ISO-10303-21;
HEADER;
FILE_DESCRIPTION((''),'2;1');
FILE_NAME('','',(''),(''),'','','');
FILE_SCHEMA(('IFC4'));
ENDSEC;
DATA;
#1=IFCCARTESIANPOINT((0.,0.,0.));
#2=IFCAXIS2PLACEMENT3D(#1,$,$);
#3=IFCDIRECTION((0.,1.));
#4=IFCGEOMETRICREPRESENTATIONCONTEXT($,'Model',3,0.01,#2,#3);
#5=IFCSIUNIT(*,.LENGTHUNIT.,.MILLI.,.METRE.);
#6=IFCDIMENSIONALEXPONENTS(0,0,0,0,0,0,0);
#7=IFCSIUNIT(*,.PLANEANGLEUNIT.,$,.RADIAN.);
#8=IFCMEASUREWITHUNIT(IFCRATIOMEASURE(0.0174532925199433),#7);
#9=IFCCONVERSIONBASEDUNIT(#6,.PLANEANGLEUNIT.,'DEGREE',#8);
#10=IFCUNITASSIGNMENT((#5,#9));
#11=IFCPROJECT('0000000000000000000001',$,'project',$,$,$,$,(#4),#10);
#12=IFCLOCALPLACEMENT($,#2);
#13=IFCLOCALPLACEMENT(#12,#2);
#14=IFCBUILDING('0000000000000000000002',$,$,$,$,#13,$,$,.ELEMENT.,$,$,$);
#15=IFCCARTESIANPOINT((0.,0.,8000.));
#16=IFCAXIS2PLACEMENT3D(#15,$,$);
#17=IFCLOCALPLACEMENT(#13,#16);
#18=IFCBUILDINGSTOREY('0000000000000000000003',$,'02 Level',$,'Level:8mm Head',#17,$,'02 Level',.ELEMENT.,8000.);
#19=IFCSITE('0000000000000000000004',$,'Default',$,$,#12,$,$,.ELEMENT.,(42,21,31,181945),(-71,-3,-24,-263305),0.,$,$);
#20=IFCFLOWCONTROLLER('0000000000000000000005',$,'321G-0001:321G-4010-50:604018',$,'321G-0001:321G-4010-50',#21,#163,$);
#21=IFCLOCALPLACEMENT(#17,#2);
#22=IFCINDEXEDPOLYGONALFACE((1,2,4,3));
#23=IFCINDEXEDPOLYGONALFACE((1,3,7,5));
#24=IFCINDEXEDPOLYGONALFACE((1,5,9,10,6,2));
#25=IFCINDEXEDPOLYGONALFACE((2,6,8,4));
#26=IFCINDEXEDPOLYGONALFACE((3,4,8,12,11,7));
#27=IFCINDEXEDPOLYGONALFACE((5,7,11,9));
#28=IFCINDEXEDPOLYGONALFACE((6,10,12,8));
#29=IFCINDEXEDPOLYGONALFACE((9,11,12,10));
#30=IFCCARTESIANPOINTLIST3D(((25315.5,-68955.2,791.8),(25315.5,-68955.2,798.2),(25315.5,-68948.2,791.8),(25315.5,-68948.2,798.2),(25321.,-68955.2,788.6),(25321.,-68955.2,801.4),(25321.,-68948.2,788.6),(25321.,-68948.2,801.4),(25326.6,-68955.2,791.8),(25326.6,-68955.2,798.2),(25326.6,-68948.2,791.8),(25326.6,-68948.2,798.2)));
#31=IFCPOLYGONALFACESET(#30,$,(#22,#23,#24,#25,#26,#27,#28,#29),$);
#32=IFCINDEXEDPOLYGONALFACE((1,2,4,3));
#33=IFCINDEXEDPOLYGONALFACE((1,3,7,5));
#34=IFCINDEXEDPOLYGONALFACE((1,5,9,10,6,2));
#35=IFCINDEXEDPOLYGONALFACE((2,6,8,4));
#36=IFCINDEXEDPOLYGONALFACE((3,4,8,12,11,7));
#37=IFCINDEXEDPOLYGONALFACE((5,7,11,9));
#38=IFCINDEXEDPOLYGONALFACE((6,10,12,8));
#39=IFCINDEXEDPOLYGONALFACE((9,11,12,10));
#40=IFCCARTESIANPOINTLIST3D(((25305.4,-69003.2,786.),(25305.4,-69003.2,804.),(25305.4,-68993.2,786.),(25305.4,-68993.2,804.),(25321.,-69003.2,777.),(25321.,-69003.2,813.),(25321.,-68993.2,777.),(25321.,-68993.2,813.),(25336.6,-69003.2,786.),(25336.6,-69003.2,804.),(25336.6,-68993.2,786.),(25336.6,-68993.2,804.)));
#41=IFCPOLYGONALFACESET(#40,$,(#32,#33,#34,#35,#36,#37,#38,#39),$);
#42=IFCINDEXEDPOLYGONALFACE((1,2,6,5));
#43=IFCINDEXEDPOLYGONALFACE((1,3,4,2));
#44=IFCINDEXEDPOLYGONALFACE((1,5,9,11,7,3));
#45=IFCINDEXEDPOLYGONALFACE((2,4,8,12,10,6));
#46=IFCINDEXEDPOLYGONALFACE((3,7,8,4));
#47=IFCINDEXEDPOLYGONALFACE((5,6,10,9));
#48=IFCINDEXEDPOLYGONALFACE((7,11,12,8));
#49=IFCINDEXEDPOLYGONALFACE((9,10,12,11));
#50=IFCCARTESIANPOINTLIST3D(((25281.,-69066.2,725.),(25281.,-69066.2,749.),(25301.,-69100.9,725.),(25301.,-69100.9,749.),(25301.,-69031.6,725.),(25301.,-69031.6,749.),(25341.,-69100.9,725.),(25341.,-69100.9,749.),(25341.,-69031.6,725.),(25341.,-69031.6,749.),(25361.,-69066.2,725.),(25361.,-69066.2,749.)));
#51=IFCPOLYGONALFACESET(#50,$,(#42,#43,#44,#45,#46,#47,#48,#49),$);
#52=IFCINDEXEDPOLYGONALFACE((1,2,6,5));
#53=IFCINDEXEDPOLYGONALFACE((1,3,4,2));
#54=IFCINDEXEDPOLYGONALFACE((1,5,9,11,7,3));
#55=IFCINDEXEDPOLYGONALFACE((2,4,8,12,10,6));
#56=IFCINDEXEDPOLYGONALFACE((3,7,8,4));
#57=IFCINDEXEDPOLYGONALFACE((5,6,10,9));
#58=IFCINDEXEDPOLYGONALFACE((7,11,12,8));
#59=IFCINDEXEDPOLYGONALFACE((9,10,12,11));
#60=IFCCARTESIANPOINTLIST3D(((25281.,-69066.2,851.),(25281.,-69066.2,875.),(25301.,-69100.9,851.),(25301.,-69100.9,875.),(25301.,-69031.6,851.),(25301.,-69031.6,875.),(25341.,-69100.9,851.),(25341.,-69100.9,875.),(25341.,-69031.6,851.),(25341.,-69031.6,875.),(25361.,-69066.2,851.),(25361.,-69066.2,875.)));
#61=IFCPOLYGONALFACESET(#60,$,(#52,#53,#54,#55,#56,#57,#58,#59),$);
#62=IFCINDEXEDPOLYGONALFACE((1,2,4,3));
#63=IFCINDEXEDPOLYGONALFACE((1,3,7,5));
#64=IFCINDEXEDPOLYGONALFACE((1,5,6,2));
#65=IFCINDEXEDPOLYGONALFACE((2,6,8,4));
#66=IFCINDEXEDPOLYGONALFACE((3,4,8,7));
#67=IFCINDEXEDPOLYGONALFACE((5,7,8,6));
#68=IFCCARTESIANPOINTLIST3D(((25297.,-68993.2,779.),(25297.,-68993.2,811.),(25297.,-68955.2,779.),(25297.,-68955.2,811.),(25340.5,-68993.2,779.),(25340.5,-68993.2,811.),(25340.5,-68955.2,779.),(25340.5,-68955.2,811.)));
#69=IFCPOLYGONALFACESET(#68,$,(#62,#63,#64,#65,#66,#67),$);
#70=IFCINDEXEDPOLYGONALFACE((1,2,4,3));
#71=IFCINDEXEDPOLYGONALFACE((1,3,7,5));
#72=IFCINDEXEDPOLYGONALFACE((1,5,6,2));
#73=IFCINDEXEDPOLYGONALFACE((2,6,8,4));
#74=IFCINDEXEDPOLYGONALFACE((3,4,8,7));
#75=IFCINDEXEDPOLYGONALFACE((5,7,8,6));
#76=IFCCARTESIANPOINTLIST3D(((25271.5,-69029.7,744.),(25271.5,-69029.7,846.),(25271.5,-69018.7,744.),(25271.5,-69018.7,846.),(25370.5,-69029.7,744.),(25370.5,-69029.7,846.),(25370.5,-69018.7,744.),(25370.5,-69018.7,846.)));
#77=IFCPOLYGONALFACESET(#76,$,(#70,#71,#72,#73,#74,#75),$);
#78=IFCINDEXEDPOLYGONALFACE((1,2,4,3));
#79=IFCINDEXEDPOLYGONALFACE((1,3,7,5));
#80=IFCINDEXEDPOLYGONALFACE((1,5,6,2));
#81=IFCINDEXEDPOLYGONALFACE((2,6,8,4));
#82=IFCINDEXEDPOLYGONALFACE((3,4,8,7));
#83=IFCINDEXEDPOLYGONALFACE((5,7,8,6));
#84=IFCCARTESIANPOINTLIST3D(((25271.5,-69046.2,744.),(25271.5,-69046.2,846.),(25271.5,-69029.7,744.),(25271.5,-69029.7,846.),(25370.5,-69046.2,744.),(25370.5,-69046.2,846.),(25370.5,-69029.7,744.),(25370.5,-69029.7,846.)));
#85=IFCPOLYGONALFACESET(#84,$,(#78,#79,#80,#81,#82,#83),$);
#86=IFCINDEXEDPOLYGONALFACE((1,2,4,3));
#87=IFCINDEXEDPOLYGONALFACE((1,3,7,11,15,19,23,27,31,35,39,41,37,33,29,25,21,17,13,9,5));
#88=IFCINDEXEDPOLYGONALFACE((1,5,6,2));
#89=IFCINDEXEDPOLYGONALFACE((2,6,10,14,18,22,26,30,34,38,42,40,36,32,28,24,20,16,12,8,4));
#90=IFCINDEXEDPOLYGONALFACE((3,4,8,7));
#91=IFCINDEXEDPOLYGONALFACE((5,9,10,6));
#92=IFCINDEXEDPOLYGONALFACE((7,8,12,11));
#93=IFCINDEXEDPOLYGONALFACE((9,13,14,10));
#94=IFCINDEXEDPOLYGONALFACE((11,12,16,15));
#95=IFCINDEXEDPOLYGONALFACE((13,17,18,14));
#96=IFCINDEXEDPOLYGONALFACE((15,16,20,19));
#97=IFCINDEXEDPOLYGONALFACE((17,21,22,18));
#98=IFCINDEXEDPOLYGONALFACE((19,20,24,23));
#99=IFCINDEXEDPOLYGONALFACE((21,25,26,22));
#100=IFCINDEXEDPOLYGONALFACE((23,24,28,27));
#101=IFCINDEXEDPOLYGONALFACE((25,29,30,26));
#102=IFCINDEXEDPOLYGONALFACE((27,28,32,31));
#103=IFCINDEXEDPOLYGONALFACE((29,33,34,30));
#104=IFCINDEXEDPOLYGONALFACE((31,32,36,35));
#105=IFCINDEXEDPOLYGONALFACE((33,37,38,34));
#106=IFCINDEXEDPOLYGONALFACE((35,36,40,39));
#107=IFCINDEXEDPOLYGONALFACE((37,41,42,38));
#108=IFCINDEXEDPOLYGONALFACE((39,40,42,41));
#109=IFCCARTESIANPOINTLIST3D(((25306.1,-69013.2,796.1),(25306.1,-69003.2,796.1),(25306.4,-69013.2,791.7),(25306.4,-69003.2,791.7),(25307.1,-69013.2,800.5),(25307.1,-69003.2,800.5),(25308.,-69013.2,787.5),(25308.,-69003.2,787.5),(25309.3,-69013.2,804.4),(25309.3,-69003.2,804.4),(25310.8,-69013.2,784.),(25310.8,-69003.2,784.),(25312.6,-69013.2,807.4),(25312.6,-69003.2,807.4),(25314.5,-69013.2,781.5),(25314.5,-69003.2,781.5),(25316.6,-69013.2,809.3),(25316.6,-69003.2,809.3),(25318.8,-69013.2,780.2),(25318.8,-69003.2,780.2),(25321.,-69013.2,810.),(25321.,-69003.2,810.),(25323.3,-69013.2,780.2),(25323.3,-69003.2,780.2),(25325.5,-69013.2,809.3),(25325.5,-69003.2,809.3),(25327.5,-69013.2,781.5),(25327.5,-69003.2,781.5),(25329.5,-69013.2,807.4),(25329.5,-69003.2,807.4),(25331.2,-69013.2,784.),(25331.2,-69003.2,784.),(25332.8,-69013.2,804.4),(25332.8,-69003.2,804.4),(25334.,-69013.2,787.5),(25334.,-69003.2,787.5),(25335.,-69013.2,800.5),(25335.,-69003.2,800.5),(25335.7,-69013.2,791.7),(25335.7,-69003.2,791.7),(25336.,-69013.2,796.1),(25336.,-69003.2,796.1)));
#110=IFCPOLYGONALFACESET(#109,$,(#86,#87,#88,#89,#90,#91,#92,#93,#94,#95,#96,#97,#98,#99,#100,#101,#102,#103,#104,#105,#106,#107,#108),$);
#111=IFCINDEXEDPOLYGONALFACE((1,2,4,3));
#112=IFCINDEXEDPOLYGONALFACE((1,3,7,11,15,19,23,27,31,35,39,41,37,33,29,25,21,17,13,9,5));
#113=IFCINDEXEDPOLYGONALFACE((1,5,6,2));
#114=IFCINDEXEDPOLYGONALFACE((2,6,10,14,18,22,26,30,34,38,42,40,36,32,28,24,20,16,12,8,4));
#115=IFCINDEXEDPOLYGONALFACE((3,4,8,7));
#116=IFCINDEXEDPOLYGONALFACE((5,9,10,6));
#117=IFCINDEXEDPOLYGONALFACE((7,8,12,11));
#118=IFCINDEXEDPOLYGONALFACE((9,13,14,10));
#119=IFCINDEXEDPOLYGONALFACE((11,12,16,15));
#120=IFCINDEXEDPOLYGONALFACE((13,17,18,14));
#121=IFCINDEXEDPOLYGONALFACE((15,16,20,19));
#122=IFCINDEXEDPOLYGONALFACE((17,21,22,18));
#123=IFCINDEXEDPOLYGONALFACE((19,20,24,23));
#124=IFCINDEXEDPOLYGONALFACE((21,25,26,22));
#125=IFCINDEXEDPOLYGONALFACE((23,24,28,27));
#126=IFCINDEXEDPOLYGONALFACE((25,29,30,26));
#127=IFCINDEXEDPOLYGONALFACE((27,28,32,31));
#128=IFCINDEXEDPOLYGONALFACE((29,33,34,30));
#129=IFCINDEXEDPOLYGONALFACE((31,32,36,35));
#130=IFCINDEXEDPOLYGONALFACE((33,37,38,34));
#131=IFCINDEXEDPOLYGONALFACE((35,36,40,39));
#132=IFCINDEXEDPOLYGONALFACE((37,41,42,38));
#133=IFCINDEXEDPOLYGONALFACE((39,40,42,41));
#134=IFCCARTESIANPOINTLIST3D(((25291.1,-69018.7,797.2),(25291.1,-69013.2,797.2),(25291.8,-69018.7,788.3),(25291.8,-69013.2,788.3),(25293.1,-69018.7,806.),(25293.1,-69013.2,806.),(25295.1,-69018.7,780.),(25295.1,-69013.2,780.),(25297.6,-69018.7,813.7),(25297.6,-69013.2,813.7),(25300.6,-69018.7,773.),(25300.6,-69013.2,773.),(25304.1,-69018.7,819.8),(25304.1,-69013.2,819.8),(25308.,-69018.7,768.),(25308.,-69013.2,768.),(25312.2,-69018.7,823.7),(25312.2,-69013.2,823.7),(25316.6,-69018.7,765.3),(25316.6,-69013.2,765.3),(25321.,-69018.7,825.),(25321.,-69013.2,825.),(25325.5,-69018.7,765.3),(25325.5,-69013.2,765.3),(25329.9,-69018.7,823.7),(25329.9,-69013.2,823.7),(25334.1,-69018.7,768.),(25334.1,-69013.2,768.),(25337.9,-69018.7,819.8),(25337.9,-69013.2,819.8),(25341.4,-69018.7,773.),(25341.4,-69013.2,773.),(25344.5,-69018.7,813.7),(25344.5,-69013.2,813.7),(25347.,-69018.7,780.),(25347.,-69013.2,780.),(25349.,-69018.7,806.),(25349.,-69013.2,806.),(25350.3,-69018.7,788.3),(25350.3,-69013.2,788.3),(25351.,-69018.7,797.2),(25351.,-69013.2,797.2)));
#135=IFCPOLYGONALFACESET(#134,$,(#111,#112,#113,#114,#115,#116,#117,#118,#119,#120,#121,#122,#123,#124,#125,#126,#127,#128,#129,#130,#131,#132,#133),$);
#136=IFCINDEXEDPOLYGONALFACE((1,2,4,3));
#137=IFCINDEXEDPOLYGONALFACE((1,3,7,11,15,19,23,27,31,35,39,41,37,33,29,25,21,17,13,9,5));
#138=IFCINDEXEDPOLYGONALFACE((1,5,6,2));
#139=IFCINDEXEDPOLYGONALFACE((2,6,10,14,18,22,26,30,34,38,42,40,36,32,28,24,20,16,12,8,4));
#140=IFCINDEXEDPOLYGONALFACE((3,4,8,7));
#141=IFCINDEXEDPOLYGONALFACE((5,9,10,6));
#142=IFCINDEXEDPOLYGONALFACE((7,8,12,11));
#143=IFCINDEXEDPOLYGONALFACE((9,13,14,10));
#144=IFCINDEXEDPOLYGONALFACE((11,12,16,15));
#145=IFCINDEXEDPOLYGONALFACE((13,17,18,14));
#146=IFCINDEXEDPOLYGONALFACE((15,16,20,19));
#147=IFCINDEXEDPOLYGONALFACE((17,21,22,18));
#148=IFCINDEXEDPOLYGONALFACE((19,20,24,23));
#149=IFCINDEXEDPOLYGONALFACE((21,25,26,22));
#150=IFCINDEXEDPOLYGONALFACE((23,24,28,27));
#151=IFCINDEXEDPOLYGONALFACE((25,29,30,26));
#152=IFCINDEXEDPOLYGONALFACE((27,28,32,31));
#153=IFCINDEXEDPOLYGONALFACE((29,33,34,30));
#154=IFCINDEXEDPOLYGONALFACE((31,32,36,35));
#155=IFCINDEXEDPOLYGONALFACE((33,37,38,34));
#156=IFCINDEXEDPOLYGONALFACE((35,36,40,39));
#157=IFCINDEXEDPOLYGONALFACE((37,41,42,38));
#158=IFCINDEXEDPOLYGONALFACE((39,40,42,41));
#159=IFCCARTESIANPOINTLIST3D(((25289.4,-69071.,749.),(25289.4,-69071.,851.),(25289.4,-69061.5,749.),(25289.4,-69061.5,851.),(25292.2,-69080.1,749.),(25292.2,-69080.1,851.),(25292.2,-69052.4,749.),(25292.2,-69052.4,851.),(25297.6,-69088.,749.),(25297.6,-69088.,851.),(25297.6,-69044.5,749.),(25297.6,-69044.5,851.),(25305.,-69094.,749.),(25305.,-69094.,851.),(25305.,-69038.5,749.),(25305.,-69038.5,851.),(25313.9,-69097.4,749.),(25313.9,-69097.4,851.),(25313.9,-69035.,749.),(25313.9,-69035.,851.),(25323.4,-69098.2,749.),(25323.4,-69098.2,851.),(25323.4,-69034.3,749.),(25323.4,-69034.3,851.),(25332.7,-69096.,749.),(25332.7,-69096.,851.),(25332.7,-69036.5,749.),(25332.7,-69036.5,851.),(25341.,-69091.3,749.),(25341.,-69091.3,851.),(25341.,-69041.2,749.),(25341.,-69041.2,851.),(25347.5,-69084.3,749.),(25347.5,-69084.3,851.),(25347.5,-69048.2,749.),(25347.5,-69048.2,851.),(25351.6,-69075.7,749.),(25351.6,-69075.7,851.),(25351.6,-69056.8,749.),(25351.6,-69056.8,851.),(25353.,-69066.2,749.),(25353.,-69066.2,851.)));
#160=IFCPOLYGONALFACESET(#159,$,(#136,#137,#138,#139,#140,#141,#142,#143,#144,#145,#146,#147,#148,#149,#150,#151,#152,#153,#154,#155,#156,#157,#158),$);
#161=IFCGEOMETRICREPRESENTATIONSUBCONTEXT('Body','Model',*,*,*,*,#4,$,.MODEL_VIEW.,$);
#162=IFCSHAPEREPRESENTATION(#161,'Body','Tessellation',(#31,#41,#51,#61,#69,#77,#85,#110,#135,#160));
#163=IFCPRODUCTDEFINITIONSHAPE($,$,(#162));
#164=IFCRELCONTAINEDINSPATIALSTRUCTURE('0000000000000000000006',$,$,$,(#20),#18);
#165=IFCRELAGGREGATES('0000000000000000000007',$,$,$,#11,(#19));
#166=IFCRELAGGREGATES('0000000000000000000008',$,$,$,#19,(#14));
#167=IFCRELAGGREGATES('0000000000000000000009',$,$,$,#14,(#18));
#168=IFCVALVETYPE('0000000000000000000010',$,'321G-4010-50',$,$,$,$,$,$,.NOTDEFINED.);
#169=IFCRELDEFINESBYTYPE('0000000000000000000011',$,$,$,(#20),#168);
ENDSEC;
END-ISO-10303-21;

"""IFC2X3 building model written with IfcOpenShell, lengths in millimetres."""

from ifc_helpers import new_model, entity, si_unit, converted_unit, direction, frame, frame_2d, origin, origin_2d_with_axis, place, context, subcontext, project, spatial, polyline, rectangle, circle, outline, extrude, source, transform, mapped, type_object, type_shapes, element, save


model = new_model("IFC2X3")

# Units and contexts
model_context = context("Model", 3, precision=0.01, world=origin(), true_north=direction((0.0, 1.0)))
body_context = subcontext(model_context, "Body", "Model", "MODEL_VIEW")
ifc_project = project(units=[si_unit("LENGTHUNIT", "METRE", prefix="MILLI"), converted_unit("PLANEANGLEUNIT", "DEGREE", entity("IfcRatioMeasure", 0.0174532925199433), si_unit("PLANEANGLEUNIT", "RADIAN"), dimensions=[0, 0, 0, 0, 0, 0, 0])], contexts=[model_context])

# Site, building, storey
site_placement = place(None, origin())
site = spatial("IfcSite", under=ifc_project, at=site_placement, Name="Default", CompositionType="ELEMENT", RefLatitude=(42, 21, 31, 181945), RefLongitude=(-71, -3, -24, -263305), RefElevation=0.0)
building_placement = place(site_placement, origin())
building = spatial("IfcBuilding", under=site, at=building_placement, CompositionType="ELEMENT")
storey_placement = place(building_placement, frame((0.0, 0.0, 8000.0)))
storey = spatial("IfcBuildingStorey", under=building, at=storey_placement, Name="02 Level", ObjectType="Level:8mm Head", LongName="02 Level", CompositionType="ELEMENT", Elevation=8000.0)

# Flow controller
valve_type_1 = type_object("IfcValveType", Name="321G-4010-50", PredefinedType="NOTDEFINED")
shared_shape_1 = source(origin(), body_context, "Body", "SweptSolid", [
    extrude(outline(polyline([(-3.2, -5.5), (3.2, -5.5), (6.4, 0.0), (3.2, 5.5), (-3.2, 5.5), (-6.4, 0.0), (-3.2, -5.5)])), frame((-5.0, 0.0, 111.0), z_axis=(0.0, 0.0, 1.0), x_axis=(-1.0, 0.0, 0.0)), (0.0, 0.0, 1.0), 7.0),
    extrude(outline(polyline([(-9.0, -15.6), (9.0, -15.6), (18.0, 0.0), (9.0, 15.6), (-9.0, 15.6), (-18.0, 0.0), (-9.0, -15.6)])), frame((-5.0, 0.0, 63.0), z_axis=(0.0, 0.0, 1.0), x_axis=(-1.0, 0.0, 0.0)), (0.0, 0.0, 1.0), 10.0),
    extrude(outline(polyline([(-20.0, -34.6), (20.0, -34.6), (40.0, 0.0), (20.0, 34.6), (-20.0, 34.6), (-40.0, 0.0), (-20.0, -34.6)])), frame((-75.0, 0.0, 0.0), z_axis=(1.0, 0.0, 0.0), x_axis=(0.0, -1.0, 0.0)), (0.0, 0.0, 1.0), 24.0),
    extrude(outline(polyline([(-20.0, -34.6), (20.0, -34.6), (40.0, 0.0), (20.0, 34.6), (-20.0, 34.6), (-40.0, 0.0), (-20.0, -34.6)])), frame((51.0, 0.0, 0.0), z_axis=(1.0, 0.0, 0.0), x_axis=(0.0, -1.0, 0.0)), (0.0, 0.0, 1.0), 24.0),
    extrude(rectangle(XDim=32.0, YDim=43.5, at=origin_2d_with_axis()), frame((-5.0, -2.2, 73.0)), (0.0, 0.0, 1.0), 38.0),
    extrude(rectangle(XDim=102.0, YDim=99.0, at=origin_2d_with_axis()), frame((-5.0, 0.0, 36.5)), (0.0, 0.0, 1.0), 11.0),
    extrude(rectangle(XDim=102.0, YDim=99.0, at=origin_2d_with_axis()), frame((-5.0, 0.0, 20.0)), (0.0, 0.0, 1.0), 16.5),
    extrude(circle(Radius=15.0, at=frame_2d((0.0, 0.0), x_axis=(1.0, 0.0))), frame((-5.0, 0.0, 53.0)), (0.0, 0.0, 1.0), 10.0),
    extrude(circle(Radius=30.0, at=frame_2d((0.0, 0.0), x_axis=(1.0, 0.0))), frame((-5.0, 0.0, 47.5)), (0.0, 0.0, 1.0), 5.5),
    extrude(circle(Radius=32.0, at=frame_2d((0.0, 0.0), x_axis=(1.0, 0.0))), frame((-51.0, 0.0, 0.0), z_axis=(1.0, 0.0, 0.0), x_axis=(0.0, 1.0, 0.0)), (0.0, 0.0, 1.0), 102.0),
])
type_shapes(valve_type_1, [shared_shape_1])
flow_controller_1_placement = place(storey_placement, frame((25321.0, -69066.2, 800.0), z_axis=(0.0, 1.0, 0.0), x_axis=(0.0, 0.0, 1.0)))
element("IfcFlowController", 1, at=flow_controller_1_placement, inside=storey, type_object=valve_type_1, Name="321G-0001:321G-4010-50:604018", ObjectType="321G-0001:321G-4010-50", context=body_context, shape_type="MappedRepresentation", body=[
    mapped(shared_shape_1, transform((0.0, 0.0, 0.0), scale=1.0)),
])

save(model, "model.ifc")
